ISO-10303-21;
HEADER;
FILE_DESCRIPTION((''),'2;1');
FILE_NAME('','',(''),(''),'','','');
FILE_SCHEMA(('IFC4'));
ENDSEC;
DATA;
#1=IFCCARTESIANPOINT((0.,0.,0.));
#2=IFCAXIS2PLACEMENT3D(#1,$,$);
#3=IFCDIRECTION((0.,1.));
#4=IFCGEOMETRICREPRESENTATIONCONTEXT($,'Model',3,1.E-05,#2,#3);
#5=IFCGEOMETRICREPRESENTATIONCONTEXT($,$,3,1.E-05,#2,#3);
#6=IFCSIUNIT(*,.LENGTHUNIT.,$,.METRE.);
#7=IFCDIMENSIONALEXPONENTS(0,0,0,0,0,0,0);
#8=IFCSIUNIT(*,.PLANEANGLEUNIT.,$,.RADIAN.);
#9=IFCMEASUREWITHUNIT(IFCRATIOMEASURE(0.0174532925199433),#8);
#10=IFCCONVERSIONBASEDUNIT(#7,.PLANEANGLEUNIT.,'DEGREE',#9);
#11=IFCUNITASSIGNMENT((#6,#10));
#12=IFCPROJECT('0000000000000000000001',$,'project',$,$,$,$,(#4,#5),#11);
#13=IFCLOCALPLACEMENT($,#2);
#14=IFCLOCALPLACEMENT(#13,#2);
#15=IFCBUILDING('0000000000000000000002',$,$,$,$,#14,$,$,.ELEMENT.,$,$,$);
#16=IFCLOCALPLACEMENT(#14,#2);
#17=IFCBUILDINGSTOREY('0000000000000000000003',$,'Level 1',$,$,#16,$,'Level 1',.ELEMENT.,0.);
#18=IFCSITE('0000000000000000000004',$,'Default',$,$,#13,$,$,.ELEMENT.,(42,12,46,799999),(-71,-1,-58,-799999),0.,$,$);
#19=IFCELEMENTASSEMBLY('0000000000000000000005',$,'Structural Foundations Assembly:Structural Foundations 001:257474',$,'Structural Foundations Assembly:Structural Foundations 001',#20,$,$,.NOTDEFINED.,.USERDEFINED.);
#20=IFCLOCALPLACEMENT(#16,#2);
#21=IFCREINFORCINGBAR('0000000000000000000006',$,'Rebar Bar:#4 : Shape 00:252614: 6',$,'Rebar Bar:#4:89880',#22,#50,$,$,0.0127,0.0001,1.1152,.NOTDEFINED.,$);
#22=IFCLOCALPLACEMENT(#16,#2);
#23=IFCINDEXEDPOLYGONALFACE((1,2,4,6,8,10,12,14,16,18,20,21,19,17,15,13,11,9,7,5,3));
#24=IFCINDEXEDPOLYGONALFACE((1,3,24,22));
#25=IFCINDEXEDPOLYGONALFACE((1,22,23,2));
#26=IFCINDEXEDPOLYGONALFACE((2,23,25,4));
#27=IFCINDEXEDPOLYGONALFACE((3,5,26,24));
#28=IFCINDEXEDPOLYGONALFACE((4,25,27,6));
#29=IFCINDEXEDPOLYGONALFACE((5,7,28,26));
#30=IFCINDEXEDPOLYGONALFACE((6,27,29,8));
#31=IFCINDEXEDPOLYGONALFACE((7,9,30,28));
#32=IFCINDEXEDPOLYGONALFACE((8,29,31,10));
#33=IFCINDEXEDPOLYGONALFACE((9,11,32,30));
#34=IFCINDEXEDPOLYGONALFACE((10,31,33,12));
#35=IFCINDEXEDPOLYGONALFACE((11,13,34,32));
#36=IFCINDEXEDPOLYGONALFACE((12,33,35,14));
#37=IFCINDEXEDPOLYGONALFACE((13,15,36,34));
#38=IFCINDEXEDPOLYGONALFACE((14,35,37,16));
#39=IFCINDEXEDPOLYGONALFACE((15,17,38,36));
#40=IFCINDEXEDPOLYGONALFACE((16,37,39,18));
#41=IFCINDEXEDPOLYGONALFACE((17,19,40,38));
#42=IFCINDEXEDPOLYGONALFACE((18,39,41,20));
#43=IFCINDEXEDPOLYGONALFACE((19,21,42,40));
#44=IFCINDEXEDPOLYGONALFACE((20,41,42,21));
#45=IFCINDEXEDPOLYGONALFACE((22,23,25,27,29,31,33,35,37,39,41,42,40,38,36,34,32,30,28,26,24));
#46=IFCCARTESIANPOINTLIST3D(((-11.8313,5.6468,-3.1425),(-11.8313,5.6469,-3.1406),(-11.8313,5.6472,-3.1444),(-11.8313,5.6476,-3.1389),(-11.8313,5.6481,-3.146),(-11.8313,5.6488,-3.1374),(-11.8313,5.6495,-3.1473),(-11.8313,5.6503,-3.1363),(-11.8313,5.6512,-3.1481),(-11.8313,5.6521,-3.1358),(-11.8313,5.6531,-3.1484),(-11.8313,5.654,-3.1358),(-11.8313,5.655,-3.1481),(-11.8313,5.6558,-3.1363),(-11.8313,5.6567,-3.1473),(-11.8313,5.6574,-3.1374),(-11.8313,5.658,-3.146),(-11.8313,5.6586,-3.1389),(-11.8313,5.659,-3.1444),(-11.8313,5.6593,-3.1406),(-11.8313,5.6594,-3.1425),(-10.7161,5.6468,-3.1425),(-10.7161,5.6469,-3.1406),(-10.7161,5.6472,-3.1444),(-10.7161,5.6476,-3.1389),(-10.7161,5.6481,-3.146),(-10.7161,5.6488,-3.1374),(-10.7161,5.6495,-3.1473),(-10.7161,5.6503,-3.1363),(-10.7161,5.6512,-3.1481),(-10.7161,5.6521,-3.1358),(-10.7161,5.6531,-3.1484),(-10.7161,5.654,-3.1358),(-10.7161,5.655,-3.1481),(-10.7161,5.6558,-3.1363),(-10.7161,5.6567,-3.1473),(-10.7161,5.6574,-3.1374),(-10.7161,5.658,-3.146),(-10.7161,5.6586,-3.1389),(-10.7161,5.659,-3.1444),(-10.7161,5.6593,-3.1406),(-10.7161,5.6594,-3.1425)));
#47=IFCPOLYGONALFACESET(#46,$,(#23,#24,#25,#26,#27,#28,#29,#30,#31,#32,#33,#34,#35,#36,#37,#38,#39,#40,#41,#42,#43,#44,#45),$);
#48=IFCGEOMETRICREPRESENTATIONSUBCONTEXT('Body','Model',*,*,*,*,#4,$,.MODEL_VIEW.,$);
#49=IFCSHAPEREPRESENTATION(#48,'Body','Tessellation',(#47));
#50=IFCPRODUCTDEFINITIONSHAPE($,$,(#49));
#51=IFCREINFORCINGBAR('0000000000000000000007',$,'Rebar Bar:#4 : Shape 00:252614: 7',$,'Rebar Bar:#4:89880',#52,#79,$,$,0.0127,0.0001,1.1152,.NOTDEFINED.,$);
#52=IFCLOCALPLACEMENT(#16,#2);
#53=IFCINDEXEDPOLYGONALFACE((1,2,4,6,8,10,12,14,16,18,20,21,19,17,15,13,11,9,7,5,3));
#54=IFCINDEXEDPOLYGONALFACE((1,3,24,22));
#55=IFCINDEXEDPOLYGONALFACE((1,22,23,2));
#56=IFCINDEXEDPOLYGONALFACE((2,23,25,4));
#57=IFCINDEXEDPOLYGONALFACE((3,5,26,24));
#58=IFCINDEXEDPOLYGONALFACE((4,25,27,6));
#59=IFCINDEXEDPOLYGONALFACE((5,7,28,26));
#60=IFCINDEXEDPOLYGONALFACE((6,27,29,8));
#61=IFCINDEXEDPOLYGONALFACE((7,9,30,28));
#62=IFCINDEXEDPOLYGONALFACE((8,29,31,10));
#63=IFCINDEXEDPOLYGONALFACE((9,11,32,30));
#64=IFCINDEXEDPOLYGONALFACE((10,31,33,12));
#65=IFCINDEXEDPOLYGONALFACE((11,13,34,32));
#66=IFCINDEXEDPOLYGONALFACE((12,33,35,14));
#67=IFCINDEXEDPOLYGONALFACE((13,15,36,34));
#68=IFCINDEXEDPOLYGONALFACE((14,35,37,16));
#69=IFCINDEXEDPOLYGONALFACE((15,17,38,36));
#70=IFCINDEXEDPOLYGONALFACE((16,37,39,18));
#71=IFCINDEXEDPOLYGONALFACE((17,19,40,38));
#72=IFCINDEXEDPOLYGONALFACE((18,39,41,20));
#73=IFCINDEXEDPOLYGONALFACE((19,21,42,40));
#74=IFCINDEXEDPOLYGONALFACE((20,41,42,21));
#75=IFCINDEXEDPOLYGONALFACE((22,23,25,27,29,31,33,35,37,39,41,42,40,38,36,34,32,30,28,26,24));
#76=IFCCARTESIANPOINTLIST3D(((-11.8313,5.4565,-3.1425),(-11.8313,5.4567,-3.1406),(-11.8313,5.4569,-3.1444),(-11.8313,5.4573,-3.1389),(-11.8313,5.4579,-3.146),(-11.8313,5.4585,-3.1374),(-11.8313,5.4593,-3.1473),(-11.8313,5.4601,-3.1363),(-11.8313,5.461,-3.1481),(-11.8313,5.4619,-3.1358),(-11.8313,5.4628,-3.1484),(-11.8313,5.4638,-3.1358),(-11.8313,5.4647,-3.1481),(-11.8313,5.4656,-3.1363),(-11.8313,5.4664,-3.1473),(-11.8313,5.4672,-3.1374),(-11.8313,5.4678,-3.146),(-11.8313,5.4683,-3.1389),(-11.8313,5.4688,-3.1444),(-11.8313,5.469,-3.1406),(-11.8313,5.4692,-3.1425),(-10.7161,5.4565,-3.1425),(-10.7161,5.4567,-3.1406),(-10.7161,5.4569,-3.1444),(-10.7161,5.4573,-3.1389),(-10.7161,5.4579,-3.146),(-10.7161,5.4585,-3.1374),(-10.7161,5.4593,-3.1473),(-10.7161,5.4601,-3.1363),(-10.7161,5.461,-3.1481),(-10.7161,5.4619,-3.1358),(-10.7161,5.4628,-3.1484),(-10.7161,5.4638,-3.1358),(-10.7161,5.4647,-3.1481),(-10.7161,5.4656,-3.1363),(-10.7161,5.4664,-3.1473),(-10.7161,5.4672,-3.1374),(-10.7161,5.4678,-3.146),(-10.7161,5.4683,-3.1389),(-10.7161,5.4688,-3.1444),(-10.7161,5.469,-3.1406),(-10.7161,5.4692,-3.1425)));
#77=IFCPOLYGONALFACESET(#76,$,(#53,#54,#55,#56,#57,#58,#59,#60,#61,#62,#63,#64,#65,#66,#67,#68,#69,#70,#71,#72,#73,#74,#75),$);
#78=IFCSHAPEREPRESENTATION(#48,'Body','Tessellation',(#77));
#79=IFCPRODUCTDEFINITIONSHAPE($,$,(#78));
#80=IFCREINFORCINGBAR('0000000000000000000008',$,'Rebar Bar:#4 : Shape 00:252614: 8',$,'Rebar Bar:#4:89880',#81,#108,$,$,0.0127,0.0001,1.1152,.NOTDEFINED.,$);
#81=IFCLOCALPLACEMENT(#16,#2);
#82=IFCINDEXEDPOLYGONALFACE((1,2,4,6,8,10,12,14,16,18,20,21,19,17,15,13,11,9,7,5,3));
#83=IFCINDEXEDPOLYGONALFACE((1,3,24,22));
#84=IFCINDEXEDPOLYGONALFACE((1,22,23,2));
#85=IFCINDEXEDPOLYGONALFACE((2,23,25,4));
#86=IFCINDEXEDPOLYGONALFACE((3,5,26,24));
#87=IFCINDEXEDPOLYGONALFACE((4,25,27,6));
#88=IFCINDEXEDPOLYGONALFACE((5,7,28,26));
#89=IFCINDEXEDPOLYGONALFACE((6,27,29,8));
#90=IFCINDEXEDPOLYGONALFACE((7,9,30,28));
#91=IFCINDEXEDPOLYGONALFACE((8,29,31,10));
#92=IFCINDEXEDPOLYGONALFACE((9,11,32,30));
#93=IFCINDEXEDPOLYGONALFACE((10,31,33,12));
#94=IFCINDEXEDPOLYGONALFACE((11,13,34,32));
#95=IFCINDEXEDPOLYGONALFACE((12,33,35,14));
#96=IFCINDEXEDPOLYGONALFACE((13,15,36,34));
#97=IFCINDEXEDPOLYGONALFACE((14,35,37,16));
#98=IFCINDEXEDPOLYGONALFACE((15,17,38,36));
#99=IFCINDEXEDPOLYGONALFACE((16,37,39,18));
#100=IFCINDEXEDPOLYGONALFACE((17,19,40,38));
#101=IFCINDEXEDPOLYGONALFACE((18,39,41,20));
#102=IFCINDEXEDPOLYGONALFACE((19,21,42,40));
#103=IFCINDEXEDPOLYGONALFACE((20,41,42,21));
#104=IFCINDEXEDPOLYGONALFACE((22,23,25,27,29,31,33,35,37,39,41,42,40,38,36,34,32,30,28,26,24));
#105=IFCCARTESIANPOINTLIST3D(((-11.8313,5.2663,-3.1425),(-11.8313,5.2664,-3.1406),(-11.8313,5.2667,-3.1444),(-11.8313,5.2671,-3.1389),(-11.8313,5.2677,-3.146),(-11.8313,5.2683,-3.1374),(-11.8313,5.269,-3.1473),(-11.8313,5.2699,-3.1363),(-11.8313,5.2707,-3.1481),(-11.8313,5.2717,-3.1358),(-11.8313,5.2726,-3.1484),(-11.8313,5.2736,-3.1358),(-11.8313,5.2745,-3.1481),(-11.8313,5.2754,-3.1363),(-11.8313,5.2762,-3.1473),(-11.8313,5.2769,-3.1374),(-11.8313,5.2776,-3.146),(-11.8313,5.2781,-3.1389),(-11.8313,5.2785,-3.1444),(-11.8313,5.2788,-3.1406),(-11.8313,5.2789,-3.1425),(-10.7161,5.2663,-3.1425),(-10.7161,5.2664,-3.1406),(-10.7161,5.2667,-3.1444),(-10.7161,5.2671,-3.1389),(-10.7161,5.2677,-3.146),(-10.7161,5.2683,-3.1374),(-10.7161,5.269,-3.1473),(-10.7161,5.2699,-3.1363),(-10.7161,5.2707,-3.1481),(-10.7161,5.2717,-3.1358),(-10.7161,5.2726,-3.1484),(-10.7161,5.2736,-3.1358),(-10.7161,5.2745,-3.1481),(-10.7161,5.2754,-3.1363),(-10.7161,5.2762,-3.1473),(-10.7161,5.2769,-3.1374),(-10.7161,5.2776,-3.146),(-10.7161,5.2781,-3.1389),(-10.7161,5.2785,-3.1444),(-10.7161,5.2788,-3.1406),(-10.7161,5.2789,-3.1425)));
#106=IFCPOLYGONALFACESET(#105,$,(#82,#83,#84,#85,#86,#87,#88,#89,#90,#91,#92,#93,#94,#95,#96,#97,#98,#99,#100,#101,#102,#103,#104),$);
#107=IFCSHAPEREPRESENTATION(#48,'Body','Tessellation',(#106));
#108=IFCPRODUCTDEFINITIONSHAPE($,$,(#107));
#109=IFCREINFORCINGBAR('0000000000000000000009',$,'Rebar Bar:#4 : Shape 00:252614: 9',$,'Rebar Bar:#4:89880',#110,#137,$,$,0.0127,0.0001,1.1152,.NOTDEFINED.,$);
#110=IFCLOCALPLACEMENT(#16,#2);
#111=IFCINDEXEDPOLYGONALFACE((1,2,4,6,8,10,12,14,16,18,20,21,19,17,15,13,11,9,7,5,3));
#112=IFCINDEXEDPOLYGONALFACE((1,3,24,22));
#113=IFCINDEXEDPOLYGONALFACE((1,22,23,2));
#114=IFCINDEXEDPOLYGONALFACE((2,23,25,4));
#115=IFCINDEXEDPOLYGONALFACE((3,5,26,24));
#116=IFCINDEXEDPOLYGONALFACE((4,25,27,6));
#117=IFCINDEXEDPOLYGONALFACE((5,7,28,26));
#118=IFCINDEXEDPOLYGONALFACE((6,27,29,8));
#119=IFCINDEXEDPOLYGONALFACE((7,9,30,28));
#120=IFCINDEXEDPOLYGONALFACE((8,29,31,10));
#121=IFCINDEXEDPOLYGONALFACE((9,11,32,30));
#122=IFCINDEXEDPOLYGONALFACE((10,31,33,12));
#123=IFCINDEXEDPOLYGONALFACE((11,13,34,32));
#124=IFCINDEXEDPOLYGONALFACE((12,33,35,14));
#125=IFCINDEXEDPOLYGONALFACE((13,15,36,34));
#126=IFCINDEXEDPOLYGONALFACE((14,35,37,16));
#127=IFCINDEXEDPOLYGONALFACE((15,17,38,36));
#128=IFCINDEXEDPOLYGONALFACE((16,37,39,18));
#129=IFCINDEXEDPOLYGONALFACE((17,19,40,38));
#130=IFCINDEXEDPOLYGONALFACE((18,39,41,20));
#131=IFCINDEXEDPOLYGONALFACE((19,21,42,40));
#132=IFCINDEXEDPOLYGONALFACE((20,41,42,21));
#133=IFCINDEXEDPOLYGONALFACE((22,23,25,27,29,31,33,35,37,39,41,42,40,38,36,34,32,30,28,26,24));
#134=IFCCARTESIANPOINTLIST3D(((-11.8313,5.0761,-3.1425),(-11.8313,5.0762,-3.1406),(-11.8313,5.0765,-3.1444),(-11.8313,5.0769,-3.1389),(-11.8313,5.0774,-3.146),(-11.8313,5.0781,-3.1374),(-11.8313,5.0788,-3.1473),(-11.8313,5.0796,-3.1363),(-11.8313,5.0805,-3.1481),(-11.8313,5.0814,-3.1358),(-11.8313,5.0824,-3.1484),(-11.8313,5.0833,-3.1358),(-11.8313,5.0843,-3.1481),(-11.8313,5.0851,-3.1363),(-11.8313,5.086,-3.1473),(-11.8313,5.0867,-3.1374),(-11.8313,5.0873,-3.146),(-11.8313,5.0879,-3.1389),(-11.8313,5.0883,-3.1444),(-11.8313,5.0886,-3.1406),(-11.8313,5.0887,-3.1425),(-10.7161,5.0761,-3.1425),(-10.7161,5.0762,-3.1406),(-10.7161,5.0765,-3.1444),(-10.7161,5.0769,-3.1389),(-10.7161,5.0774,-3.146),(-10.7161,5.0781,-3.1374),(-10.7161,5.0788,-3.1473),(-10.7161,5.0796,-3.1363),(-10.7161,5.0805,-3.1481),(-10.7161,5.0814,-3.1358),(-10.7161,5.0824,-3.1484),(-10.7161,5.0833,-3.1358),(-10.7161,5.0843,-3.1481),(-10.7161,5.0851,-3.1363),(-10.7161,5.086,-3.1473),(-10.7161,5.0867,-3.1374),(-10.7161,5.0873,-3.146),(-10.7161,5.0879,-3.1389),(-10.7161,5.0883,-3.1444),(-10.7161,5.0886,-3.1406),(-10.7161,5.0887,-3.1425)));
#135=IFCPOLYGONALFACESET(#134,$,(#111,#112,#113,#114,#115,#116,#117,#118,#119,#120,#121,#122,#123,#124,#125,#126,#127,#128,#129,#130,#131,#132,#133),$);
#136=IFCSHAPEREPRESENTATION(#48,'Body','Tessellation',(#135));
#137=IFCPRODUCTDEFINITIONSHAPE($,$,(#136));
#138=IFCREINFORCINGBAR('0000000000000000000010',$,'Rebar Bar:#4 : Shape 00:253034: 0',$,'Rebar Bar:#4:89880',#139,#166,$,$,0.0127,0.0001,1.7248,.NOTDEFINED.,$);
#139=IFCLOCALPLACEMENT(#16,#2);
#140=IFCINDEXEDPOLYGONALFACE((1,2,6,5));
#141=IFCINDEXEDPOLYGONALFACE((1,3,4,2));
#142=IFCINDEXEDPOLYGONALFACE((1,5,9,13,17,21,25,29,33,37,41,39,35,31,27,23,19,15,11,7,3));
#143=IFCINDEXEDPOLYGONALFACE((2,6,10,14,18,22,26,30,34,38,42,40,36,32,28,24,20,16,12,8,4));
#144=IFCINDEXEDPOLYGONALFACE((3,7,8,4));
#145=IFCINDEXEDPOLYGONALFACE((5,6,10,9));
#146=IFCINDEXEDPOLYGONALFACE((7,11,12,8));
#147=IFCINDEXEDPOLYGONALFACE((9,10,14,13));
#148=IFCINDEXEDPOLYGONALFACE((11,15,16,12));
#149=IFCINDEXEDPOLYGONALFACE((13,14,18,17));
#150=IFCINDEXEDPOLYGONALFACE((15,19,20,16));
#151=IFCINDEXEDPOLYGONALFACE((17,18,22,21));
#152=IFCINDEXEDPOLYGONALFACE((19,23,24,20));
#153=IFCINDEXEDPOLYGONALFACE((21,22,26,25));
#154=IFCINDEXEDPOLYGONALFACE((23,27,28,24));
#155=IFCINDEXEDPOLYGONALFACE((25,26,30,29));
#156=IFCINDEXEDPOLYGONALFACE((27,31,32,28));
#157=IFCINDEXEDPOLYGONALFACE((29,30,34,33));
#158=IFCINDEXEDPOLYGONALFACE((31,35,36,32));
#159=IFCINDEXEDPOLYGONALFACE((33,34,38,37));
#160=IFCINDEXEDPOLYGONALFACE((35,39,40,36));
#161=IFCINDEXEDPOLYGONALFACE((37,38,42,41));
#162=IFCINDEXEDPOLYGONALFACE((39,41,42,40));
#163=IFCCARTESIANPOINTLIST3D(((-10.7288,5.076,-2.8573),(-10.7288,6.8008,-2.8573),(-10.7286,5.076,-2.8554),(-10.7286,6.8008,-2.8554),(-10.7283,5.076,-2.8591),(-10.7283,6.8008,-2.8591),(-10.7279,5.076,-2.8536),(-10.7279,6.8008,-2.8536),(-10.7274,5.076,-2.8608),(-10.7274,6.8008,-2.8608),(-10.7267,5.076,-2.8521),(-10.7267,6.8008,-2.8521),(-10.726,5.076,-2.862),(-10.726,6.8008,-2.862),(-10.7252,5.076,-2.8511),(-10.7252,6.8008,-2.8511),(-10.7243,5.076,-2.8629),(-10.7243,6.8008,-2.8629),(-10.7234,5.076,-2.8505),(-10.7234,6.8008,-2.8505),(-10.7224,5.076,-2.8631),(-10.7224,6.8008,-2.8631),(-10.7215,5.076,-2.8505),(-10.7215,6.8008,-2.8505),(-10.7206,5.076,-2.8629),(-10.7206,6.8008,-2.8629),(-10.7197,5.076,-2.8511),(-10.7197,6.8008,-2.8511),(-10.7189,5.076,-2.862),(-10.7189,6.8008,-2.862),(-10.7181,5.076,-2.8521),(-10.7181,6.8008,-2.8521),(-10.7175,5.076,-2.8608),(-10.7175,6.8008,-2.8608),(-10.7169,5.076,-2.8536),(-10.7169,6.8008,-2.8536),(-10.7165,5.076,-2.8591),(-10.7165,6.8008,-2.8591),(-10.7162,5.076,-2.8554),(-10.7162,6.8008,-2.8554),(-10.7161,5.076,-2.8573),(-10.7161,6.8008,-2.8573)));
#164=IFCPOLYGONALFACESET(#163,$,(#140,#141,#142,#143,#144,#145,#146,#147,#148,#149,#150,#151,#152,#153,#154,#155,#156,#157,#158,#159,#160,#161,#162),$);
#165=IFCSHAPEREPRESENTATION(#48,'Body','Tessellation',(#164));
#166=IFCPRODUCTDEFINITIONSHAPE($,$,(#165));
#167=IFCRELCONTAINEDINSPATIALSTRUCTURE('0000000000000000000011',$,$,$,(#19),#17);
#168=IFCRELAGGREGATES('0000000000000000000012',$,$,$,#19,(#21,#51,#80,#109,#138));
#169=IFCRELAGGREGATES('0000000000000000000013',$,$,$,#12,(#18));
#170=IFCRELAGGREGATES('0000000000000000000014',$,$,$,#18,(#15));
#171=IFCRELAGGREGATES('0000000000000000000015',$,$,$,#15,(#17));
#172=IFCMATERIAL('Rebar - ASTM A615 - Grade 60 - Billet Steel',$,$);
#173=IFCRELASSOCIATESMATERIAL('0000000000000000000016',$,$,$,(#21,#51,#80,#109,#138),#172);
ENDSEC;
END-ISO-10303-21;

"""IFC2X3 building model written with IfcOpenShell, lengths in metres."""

from ifc_helpers import new_model, entity, si_unit, converted_unit, direction, origin, place, context, subcontext, project, spatial, material, element, aggregate, save


model = new_model("IFC2X3")

# Units and contexts
model_context = context("Model", 3, precision=1e-05, world=origin(), true_north=direction((0.0, 1.0)))
context_of_model = context(None, 3, precision=1e-05, world=origin(), true_north=direction((0.0, 1.0)))
body_context = subcontext(model_context, "Body", "Model", "MODEL_VIEW")
ifc_project = project(units=[si_unit("LENGTHUNIT", "METRE"), converted_unit("PLANEANGLEUNIT", "DEGREE", entity("IfcRatioMeasure", 0.0174532925199433), si_unit("PLANEANGLEUNIT", "RADIAN"), dimensions=[0, 0, 0, 0, 0, 0, 0])], contexts=[model_context, context_of_model])

# Site, building, storey
site_placement = place(None, origin())
site = spatial("IfcSite", under=ifc_project, at=site_placement, Name="Default", CompositionType="ELEMENT", RefLatitude=(42, 12, 46, 799999), RefLongitude=(-71, -1, -58, -799999), RefElevation=0.0)
building_placement = place(site_placement, origin())
building = spatial("IfcBuilding", under=site, at=building_placement, CompositionType="ELEMENT")
storey_placement = place(building_placement, origin())
storey = spatial("IfcBuildingStorey", under=building, at=storey_placement, Name="Level 1", LongName="Level 1", CompositionType="ELEMENT", Elevation=0.0)

# Element assembly, reinforcing bars
assembly_placement = place(storey_placement, origin())
assembly = element("IfcElementAssembly", 1, at=assembly_placement, inside=storey, Name="Structural Foundations Assembly:Structural Foundations 001:257474", ObjectType="Structural Foundations Assembly:Structural Foundations 001", AssemblyPlace="NOTDEFINED", PredefinedType="USERDEFINED")
ifc_material = material(Name="Rebar - ASTM A615 - Grade 60 - Billet Steel")
reinforcing_bar_1_placement = place(assembly_placement, origin())
reinforcing_bar_1 = element("IfcReinforcingBar", 2, at=reinforcing_bar_1_placement, material=ifc_material, Name="Rebar Bar:#4 : Shape 00:252614: 6", ObjectType="Rebar Bar:#4:89880", BarLength=1.1152, BarRole="NOTDEFINED", CrossSectionArea=0.0001, NominalDiameter=0.0127, context=body_context, shape_type="AdvancedSweptSolid", body=[
    entity("IfcSweptDiskSolid", entity("IfcCompositeCurve", [entity("IfcCompositeCurveSegment", "CONTINUOUS", True, entity("IfcPolyline", [entity("IfcCartesianPoint", [-10.7161, 5.6531, -3.142]), entity("IfcCartesianPoint", [-11.8313, 5.6531, -3.142])]))], False), 0.0063, None, 0.0, 1.0),
])
reinforcing_bar_2_placement = place(assembly_placement, origin())
reinforcing_bar_2 = element("IfcReinforcingBar", 3, at=reinforcing_bar_2_placement, material=ifc_material, Name="Rebar Bar:#4 : Shape 00:252614: 7", ObjectType="Rebar Bar:#4:89880", BarLength=1.1152, BarRole="NOTDEFINED", CrossSectionArea=0.0001, NominalDiameter=0.0127, context=body_context, shape_type="AdvancedSweptSolid", body=[
    entity("IfcSweptDiskSolid", entity("IfcCompositeCurve", [entity("IfcCompositeCurveSegment", "CONTINUOUS", True, entity("IfcPolyline", [entity("IfcCartesianPoint", [-10.7161, 5.4628, -3.142]), entity("IfcCartesianPoint", [-11.8313, 5.4628, -3.142])]))], False), 0.0063, None, 0.0, 1.0),
])
reinforcing_bar_3_placement = place(assembly_placement, origin())
reinforcing_bar_3 = element("IfcReinforcingBar", 4, at=reinforcing_bar_3_placement, material=ifc_material, Name="Rebar Bar:#4 : Shape 00:252614: 8", ObjectType="Rebar Bar:#4:89880", BarLength=1.1152, BarRole="NOTDEFINED", CrossSectionArea=0.0001, NominalDiameter=0.0127, context=body_context, shape_type="AdvancedSweptSolid", body=[
    entity("IfcSweptDiskSolid", entity("IfcCompositeCurve", [entity("IfcCompositeCurveSegment", "CONTINUOUS", True, entity("IfcPolyline", [entity("IfcCartesianPoint", [-10.7161, 5.2726, -3.142]), entity("IfcCartesianPoint", [-11.8313, 5.2726, -3.142])]))], False), 0.0063, None, 0.0, 1.0),
])
reinforcing_bar_4_placement = place(assembly_placement, origin())
reinforcing_bar_4 = element("IfcReinforcingBar", 5, at=reinforcing_bar_4_placement, material=ifc_material, Name="Rebar Bar:#4 : Shape 00:252614: 9", ObjectType="Rebar Bar:#4:89880", BarLength=1.1152, BarRole="NOTDEFINED", CrossSectionArea=0.0001, NominalDiameter=0.0127, context=body_context, shape_type="AdvancedSweptSolid", body=[
    entity("IfcSweptDiskSolid", entity("IfcCompositeCurve", [entity("IfcCompositeCurveSegment", "CONTINUOUS", True, entity("IfcPolyline", [entity("IfcCartesianPoint", [-10.7161, 5.0824, -3.142]), entity("IfcCartesianPoint", [-11.8313, 5.0824, -3.142])]))], False), 0.0063, None, 0.0, 1.0),
])
reinforcing_bar_5_placement = place(assembly_placement, origin())
reinforcing_bar_5 = element("IfcReinforcingBar", 6, at=reinforcing_bar_5_placement, material=ifc_material, Name="Rebar Bar:#4 : Shape 00:253034: 0", ObjectType="Rebar Bar:#4:89880", BarLength=1.7248, BarRole="NOTDEFINED", CrossSectionArea=0.0001, NominalDiameter=0.0127, context=body_context, shape_type="AdvancedSweptSolid", body=[
    entity("IfcSweptDiskSolid", entity("IfcCompositeCurve", [entity("IfcCompositeCurveSegment", "CONTINUOUS", True, entity("IfcPolyline", [entity("IfcCartesianPoint", [-10.7224, 6.8008, -2.8568]), entity("IfcCartesianPoint", [-10.7224, 5.076, -2.8568])]))], False), 0.0063, None, 0.0, 1.0),
])
aggregate(assembly, [reinforcing_bar_1, reinforcing_bar_2, reinforcing_bar_3, reinforcing_bar_4, reinforcing_bar_5])

save(model, "model.ifc")
